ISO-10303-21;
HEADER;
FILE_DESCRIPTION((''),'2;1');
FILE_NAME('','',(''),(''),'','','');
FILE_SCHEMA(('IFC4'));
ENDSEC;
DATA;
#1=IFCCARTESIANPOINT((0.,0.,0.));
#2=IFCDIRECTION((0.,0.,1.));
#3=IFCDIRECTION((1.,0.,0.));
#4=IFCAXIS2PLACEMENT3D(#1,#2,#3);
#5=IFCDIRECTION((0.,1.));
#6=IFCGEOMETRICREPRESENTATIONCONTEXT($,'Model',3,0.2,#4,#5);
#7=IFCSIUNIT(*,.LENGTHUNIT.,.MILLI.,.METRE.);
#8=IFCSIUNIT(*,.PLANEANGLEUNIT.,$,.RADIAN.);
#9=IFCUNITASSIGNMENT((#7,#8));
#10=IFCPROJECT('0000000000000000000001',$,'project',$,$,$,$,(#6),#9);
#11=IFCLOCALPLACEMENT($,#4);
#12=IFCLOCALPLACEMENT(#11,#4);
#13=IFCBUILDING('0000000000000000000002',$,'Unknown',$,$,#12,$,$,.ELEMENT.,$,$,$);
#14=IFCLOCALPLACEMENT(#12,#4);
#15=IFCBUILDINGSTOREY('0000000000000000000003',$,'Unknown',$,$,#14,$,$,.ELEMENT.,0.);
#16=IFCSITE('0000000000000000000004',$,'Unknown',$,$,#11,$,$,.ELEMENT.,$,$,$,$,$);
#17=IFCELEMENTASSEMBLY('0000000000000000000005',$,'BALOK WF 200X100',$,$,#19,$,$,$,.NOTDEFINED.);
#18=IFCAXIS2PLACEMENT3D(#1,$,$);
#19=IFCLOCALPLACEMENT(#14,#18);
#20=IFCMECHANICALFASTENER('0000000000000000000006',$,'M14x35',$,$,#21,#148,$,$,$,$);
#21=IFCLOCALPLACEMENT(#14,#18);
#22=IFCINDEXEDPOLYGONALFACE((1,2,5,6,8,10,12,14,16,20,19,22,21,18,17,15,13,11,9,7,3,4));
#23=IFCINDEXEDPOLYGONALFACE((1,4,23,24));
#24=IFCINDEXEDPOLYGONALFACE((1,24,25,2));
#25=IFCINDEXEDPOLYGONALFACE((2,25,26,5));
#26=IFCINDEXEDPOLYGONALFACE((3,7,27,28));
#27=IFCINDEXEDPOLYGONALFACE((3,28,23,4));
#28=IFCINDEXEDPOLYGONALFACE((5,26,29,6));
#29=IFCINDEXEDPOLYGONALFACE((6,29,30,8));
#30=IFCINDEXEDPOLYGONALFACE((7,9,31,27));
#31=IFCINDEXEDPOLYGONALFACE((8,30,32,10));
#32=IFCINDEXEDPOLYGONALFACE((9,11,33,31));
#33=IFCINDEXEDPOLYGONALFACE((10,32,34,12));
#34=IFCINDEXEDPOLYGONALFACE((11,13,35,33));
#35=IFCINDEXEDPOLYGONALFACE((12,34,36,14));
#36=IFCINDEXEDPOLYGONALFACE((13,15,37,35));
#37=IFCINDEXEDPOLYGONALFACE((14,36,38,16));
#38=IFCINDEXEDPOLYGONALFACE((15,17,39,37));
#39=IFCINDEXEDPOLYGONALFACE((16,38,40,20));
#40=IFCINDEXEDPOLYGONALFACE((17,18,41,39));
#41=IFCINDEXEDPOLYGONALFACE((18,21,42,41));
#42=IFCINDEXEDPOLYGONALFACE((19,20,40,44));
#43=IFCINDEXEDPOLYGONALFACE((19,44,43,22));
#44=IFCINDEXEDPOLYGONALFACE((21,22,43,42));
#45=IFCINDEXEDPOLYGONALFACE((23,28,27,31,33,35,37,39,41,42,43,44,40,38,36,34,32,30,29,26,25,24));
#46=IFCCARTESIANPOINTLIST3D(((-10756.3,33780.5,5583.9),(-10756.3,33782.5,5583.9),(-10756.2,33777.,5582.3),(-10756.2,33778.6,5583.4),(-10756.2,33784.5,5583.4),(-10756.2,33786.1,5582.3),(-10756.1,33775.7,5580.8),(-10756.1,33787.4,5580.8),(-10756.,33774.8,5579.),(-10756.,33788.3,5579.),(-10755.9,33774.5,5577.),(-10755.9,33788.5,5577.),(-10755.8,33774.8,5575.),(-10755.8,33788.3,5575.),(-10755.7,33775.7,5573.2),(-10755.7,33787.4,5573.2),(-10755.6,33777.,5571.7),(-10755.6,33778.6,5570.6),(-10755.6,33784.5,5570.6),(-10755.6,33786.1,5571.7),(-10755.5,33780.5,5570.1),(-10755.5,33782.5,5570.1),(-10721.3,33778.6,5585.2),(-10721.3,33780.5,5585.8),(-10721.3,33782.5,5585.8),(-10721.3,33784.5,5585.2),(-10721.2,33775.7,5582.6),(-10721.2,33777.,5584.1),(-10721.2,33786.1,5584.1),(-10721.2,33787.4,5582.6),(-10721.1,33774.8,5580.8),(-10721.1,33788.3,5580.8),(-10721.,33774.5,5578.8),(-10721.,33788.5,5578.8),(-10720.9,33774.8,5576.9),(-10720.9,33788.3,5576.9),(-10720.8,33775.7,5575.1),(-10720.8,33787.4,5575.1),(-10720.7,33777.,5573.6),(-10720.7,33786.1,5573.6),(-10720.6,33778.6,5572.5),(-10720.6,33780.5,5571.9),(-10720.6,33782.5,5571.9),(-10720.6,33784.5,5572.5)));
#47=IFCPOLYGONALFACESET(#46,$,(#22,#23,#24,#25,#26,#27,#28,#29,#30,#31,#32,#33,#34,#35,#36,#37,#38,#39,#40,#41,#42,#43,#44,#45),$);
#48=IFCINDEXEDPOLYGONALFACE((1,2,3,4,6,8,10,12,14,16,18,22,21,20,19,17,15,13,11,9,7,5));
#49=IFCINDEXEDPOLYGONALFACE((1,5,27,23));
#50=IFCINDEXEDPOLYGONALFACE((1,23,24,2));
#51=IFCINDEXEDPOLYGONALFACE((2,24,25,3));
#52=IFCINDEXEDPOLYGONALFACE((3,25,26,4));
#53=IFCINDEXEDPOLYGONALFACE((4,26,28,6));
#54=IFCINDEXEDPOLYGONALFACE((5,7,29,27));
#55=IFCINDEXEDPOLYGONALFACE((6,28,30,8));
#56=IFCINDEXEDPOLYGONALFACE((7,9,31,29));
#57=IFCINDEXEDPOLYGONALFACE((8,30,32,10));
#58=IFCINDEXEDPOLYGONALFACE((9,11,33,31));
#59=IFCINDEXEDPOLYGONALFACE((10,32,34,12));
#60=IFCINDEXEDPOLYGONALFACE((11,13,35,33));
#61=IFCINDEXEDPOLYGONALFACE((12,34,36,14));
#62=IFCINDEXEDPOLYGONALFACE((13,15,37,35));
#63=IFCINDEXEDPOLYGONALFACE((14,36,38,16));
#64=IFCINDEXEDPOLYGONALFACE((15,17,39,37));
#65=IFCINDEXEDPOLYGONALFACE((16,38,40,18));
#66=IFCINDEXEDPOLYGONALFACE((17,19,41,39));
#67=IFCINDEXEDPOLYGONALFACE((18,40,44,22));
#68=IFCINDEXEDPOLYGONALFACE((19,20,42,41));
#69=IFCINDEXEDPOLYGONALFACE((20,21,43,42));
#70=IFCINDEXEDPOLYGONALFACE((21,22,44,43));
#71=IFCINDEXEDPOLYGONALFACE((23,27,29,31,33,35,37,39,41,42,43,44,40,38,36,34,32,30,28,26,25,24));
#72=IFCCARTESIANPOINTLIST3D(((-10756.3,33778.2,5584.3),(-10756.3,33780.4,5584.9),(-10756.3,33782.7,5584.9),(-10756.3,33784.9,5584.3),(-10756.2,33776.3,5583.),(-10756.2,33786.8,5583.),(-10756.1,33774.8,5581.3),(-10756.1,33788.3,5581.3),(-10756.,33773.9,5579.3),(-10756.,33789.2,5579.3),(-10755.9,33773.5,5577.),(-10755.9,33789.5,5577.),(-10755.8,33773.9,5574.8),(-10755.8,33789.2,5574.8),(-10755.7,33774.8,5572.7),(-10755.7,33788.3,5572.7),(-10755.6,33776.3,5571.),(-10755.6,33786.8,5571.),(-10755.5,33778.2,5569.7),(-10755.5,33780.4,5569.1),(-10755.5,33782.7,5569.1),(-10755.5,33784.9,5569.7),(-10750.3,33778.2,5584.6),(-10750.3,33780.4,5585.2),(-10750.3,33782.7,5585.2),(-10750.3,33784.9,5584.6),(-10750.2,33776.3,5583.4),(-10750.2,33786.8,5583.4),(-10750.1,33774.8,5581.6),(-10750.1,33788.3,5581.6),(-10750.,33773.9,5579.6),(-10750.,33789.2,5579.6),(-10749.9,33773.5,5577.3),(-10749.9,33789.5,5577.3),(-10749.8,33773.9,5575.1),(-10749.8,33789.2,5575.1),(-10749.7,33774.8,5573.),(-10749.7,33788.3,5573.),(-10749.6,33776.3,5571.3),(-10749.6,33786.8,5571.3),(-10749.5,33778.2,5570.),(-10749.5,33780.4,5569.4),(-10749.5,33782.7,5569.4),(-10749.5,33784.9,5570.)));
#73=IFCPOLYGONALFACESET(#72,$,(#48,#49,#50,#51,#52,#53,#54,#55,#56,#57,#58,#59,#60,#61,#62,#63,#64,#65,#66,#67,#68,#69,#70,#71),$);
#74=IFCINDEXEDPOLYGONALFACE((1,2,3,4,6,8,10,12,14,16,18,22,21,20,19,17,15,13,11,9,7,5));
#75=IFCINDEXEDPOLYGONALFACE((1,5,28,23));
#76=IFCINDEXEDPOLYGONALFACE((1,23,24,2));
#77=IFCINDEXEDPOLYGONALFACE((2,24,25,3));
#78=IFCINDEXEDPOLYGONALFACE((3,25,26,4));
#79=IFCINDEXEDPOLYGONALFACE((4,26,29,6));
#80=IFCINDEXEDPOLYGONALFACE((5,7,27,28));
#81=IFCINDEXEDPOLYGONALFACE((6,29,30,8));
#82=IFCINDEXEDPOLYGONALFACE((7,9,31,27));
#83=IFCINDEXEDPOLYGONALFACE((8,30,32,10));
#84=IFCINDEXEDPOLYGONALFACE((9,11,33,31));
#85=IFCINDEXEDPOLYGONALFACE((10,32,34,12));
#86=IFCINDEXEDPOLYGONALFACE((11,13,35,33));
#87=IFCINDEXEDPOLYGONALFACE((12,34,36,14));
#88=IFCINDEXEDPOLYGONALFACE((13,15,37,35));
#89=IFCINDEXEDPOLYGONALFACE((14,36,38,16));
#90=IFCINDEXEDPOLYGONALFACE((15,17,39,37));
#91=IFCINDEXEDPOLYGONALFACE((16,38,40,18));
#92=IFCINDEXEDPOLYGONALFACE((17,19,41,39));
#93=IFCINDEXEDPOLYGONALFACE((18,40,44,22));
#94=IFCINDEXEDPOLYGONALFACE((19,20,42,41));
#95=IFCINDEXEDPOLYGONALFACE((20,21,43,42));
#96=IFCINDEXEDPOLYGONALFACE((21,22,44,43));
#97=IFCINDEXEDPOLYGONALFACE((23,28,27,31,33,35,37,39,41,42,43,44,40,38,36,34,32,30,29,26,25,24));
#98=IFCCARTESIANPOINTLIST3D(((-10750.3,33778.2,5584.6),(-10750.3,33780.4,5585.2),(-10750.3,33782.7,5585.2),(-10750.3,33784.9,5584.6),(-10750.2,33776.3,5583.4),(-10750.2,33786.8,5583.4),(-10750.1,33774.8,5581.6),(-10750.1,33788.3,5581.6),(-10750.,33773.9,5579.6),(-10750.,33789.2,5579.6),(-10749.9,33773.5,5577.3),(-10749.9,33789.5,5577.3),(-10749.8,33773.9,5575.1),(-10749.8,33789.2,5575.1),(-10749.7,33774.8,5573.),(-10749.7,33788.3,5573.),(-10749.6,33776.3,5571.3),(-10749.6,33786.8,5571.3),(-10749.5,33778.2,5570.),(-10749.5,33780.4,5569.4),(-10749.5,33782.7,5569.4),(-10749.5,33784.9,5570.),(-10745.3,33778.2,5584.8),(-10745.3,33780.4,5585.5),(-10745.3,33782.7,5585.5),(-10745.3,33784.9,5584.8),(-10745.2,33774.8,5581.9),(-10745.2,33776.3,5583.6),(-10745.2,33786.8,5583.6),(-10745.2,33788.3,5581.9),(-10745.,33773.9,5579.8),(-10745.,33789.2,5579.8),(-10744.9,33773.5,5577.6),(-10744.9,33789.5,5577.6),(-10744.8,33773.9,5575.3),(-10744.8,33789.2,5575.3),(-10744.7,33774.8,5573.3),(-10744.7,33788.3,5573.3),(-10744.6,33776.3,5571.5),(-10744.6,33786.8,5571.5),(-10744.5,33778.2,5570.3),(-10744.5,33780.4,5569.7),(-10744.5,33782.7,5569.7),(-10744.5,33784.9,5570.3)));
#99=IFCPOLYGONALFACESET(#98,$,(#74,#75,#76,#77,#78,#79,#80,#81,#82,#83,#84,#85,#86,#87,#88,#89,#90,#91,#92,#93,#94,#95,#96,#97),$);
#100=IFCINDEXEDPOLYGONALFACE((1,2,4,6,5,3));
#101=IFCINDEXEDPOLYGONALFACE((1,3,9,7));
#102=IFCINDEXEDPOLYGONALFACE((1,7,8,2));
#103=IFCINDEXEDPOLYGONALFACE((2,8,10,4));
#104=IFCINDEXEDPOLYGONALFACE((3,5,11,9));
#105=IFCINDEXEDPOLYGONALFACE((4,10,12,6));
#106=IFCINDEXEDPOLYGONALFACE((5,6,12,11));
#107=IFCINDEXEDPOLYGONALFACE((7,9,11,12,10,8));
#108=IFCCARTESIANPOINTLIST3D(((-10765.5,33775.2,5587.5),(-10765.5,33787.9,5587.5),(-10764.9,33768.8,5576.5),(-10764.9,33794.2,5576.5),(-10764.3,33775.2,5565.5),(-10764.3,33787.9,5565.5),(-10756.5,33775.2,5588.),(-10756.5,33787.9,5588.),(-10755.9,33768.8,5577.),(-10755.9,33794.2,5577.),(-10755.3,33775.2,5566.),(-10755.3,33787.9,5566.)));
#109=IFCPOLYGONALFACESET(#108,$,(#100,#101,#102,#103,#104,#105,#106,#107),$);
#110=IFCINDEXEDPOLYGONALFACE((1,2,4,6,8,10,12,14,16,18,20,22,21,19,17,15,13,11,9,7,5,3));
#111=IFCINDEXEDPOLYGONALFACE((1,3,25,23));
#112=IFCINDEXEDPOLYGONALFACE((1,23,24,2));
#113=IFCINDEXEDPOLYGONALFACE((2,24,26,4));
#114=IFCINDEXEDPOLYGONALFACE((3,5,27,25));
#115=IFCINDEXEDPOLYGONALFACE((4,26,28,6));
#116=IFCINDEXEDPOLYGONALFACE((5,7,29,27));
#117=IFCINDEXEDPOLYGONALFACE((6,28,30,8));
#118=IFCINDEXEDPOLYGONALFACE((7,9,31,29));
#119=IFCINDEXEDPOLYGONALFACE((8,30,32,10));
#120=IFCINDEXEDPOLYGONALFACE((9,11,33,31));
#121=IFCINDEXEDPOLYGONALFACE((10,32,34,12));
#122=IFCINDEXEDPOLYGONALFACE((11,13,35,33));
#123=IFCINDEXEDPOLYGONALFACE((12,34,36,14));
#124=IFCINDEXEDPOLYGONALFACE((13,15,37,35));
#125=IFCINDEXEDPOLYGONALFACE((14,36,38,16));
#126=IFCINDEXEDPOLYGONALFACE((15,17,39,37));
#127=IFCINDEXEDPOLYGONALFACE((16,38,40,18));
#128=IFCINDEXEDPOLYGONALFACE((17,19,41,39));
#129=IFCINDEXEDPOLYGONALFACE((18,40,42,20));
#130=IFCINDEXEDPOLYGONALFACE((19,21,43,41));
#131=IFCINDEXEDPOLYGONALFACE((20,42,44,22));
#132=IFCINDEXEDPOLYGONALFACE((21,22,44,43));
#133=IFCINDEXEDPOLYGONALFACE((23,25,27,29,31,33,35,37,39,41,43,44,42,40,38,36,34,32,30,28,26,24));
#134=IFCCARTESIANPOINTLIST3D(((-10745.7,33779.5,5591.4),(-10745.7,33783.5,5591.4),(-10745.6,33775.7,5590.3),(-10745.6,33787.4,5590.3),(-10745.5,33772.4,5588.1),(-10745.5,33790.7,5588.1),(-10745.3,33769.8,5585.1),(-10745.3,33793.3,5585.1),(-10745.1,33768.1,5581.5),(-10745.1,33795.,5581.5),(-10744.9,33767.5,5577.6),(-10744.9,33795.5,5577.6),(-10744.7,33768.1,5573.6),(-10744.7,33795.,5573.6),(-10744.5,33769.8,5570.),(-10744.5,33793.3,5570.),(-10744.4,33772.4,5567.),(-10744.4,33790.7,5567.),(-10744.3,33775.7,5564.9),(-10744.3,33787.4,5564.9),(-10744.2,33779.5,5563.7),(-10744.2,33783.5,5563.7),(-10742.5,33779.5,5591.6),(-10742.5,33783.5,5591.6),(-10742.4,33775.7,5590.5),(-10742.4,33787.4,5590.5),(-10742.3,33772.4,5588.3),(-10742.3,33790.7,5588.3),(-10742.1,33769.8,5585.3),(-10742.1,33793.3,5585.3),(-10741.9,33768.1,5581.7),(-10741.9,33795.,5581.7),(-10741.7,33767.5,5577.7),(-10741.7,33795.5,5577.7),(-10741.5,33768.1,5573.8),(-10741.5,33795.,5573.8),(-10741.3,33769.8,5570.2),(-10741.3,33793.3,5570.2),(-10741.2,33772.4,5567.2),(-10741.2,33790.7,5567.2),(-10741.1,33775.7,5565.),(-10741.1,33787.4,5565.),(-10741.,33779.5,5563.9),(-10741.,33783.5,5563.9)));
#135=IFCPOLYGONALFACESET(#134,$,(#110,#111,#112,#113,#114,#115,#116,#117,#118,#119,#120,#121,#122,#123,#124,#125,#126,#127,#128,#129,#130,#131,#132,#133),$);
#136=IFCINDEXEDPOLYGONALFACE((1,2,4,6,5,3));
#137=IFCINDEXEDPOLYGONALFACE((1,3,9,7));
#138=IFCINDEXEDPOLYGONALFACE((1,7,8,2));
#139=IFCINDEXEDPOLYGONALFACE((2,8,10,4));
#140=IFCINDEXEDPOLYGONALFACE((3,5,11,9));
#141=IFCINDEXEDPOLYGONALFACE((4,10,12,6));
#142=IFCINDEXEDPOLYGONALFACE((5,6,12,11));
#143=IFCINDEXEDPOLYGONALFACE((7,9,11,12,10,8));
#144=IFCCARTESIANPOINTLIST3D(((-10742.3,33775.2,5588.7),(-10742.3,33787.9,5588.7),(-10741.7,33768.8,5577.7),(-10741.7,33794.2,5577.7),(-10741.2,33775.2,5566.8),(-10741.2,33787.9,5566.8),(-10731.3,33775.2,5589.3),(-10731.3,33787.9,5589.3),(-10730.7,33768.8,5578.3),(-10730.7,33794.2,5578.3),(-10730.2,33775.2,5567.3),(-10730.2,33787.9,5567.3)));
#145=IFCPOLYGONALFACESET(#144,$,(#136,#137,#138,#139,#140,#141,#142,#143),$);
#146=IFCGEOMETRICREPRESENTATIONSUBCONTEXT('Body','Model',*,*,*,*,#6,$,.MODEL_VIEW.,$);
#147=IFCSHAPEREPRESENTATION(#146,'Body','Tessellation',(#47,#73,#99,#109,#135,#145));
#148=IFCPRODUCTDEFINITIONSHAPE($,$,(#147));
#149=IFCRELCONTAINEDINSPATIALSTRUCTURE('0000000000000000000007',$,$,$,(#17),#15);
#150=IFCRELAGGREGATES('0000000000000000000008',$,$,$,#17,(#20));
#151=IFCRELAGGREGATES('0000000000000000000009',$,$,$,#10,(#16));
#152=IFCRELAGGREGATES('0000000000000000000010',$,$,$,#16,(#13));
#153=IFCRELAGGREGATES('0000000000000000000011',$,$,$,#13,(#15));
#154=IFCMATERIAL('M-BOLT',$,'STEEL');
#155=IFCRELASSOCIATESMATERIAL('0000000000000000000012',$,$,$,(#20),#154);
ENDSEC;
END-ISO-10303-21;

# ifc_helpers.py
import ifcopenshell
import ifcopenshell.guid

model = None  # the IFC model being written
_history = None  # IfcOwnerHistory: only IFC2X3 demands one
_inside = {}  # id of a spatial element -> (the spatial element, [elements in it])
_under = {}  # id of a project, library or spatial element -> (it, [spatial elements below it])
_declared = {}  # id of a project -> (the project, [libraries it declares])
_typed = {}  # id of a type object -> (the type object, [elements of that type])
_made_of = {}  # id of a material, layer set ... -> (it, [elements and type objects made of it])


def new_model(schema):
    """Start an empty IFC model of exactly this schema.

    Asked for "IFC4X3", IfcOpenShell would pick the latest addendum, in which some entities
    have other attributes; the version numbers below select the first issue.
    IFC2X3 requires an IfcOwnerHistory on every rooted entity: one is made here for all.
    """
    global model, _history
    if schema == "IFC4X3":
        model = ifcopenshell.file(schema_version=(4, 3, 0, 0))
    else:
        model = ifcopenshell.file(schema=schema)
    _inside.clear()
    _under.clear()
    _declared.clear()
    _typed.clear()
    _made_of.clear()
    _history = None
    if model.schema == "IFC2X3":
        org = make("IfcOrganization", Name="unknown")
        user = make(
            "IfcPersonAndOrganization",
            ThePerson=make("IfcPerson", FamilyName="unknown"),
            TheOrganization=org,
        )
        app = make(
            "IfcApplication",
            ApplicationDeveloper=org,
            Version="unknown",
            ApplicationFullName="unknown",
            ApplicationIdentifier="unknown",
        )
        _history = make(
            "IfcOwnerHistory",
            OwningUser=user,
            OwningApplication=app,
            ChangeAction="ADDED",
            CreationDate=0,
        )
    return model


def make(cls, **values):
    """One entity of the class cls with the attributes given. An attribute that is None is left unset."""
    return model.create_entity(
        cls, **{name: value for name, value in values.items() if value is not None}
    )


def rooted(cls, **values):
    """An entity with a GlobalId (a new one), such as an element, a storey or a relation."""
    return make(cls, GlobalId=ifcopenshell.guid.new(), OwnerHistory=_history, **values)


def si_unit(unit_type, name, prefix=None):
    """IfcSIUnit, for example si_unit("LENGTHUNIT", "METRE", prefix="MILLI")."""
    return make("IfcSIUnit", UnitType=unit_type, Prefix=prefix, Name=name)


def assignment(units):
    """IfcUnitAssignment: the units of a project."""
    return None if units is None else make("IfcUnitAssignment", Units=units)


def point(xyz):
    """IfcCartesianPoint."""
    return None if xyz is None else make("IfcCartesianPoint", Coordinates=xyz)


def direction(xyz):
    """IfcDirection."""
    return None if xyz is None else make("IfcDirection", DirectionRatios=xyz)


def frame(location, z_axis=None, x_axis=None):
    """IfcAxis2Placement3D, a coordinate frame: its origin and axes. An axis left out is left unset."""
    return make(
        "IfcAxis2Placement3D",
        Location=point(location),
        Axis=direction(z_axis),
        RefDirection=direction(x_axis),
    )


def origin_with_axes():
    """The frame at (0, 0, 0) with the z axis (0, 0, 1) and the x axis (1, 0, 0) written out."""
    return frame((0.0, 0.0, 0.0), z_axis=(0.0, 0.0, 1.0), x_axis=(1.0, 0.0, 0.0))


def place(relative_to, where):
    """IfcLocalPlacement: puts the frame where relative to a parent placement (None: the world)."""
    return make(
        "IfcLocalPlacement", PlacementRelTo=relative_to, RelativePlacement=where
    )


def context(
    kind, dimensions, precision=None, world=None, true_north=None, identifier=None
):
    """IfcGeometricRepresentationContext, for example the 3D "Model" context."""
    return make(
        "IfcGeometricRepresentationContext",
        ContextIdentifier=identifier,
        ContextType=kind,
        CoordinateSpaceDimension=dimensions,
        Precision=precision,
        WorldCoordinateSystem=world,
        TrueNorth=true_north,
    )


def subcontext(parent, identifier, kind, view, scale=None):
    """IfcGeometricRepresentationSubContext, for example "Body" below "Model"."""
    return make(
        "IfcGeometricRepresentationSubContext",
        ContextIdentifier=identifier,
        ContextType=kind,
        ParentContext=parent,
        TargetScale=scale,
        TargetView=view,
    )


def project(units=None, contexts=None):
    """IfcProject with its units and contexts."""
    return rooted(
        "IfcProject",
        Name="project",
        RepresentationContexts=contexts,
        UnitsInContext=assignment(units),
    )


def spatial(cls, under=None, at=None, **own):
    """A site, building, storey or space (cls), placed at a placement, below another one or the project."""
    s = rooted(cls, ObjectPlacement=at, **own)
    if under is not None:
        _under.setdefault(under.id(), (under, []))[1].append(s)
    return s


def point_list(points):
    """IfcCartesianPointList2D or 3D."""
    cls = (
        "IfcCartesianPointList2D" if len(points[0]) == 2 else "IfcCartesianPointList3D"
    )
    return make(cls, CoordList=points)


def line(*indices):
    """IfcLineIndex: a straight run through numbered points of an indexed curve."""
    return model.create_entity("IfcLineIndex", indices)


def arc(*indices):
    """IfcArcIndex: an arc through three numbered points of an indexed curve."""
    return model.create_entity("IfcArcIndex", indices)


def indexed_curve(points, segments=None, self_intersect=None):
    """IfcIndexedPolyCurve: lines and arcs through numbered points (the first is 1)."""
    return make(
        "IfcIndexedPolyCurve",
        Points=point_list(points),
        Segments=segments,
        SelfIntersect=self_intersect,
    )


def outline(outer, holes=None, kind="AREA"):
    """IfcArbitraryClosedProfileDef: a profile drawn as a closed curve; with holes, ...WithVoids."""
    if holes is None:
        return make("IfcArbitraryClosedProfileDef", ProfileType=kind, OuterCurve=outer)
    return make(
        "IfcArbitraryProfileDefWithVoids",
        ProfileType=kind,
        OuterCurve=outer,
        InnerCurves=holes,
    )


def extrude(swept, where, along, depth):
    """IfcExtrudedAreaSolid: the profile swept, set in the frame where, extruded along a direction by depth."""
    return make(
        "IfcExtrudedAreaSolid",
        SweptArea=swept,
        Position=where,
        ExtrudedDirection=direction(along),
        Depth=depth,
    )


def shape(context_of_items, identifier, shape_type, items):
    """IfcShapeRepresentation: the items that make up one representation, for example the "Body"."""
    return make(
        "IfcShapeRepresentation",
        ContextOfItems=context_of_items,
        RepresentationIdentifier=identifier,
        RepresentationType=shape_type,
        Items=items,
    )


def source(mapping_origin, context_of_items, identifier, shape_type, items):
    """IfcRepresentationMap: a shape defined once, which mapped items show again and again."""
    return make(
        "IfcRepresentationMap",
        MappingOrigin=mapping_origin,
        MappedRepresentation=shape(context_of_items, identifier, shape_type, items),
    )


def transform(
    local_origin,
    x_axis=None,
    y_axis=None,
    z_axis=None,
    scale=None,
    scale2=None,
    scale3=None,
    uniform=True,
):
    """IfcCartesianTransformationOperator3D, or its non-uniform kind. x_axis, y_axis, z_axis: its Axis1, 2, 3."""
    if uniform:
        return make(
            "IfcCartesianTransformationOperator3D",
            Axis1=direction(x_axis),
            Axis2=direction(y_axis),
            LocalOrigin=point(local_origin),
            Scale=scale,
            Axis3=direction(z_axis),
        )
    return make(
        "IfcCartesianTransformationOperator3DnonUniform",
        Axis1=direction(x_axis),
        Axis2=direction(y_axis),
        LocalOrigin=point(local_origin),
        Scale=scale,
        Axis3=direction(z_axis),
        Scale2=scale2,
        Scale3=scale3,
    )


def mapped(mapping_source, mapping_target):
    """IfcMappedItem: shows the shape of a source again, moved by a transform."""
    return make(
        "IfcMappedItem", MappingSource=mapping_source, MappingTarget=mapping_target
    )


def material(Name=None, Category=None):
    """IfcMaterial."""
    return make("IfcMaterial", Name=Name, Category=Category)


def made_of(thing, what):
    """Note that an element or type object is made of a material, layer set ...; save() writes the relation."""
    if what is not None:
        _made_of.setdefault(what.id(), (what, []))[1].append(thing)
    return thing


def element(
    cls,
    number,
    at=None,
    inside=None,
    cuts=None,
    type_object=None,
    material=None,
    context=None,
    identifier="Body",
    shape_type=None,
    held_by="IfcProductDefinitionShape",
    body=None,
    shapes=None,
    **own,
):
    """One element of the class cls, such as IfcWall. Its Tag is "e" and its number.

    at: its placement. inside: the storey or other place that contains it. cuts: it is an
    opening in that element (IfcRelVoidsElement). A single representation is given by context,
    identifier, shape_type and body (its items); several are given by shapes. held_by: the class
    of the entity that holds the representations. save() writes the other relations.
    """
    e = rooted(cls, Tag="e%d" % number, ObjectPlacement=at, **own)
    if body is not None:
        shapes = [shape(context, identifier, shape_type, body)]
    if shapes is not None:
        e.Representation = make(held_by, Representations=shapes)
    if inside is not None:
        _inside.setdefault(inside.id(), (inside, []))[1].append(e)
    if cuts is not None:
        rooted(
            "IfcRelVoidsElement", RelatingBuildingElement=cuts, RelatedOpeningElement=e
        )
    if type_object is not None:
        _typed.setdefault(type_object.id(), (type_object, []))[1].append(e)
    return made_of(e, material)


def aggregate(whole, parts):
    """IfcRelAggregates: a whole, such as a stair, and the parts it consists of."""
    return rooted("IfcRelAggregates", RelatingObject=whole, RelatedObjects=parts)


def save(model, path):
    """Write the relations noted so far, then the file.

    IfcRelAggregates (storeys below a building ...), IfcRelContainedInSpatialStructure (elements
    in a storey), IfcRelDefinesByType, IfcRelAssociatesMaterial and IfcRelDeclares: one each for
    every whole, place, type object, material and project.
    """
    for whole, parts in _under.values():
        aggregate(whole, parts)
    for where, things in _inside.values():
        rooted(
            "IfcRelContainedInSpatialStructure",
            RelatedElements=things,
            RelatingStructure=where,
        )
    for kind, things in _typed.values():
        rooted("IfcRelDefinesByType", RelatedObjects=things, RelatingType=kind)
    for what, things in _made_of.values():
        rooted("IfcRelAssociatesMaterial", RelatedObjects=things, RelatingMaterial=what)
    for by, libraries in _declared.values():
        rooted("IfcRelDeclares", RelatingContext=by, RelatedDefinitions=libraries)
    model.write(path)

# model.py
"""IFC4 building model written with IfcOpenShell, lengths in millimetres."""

from ifc_helpers import new_model, si_unit, direction, frame, origin_with_axes, place, context, subcontext, project, spatial, line, arc, indexed_curve, outline, extrude, source, transform, mapped, material, element, aggregate, save


model = new_model("IFC4")

# Units and contexts
model_context = context("Model", 3, precision=0.2, world=origin_with_axes(), true_north=direction((0.0, 1.0)))
body_context = subcontext(model_context, "Body", "Model", "MODEL_VIEW")
ifc_project = project(units=[si_unit("LENGTHUNIT", "METRE", prefix="MILLI"), si_unit("PLANEANGLEUNIT", "RADIAN")], contexts=[model_context])

# Site, building, storey
site_placement = place(None, origin_with_axes())
site = spatial("IfcSite", under=ifc_project, at=site_placement, Name="Unknown", CompositionType="ELEMENT")
building_placement = place(site_placement, origin_with_axes())
building = spatial("IfcBuilding", under=site, at=building_placement, Name="Unknown", CompositionType="ELEMENT")
storey_placement = place(building_placement, origin_with_axes())
storey = spatial("IfcBuildingStorey", under=building, at=storey_placement, Name="Unknown", CompositionType="ELEMENT", Elevation=0.0)

# Shared definitions
ifc_material_1 = material(Name="M-BOLT", Category="STEEL")

# Element assembly, mechanical fastener
assembly_1_placement = place(storey_placement, frame((-7044.1, 33866.5, 5721.5), z_axis=(0.0, 1.0, 0.0), x_axis=(-0.99863, 0.0, -0.052336)))
assembly_1 = element("IfcElementAssembly", 1, at=assembly_1_placement, inside=storey, Name="BALOK WF 200X100", PredefinedType="NOTDEFINED")
shared_shape_1 = source(origin_with_axes(), body_context, "Body", "SweptSolid", [
    extrude(outline(indexed_curve([(7.0, 0.0), (0.0, 7.0), (-7.0, 0.0), (0.0, -7.0)], segments=[arc(1, 2, 3), arc(3, 4, 1)])), frame((0.0, 0.0, 0.0), z_axis=(0.0, 0.0, -1.0), x_axis=(0.0, 1.0, 0.0)), (0.0, 0.0, 1.0), 35.0),
    extrude(outline(indexed_curve([(8.0, 0.0), (0.0, 8.0), (-8.0, 0.0), (0.0, -8.0)], segments=[arc(1, 2, 3), arc(3, 4, 1)])), frame((0.0, 0.0, 0.0), z_axis=(0.0, 0.0, -1.0), x_axis=(0.0, 1.0, 0.0)), (0.0, 0.0, 1.0), 6.0),
    extrude(outline(indexed_curve([(8.0, 0.0), (0.0, 8.0), (-8.0, 0.0), (0.0, -8.0)], segments=[arc(1, 2, 3), arc(3, 4, 1)])), frame((0.0, 0.0, -6.0), z_axis=(0.0, 0.0, -1.0), x_axis=(0.0, 1.0, 0.0)), (0.0, 0.0, 1.0), 5.0),
    extrude(outline(indexed_curve([(12.7, 0.0), (6.4, 11.0), (-6.4, 11.0), (-12.7, 0.0), (-6.4, -11.0), (6.4, -11.0)], segments=[line(1, 2, 3, 4, 5, 6, 1)])), frame((0.0, 0.0, 9.0), z_axis=(0.0, 0.0, -1.0), x_axis=(0.0, 1.0, 0.0)), (0.0, 0.0, 1.0), 9.0),
    extrude(outline(indexed_curve([(14.0, 0.0), (0.0, 14.0), (-14.0, 0.0), (0.0, -14.0)], segments=[arc(1, 2, 3), arc(3, 4, 1)])), frame((0.0, 0.0, -11.0), z_axis=(0.0, 0.0, -1.0), x_axis=(0.0, 1.0, 0.0)), (0.0, 0.0, 1.0), 3.2),
    extrude(outline(indexed_curve([(12.7, 0.0), (6.4, 11.0), (-6.4, 11.0), (-12.7, 0.0), (-6.4, -11.0), (6.4, -11.0)], segments=[line(1, 2, 3, 4, 5, 6, 1)])), frame((0.0, 0.0, -14.2), z_axis=(0.0, 0.0, -1.0), x_axis=(0.0, 1.0, 0.0)), (0.0, 0.0, 1.0), 11.0),
])
mechanical_fastener_1_placement = place(assembly_1_placement, frame((3714.2, 50.0, -85.0), z_axis=(1.0, 0.0, -0.000006), x_axis=(0.0, -1.0, 0.0)))
mechanical_fastener_1 = element("IfcMechanicalFastener", 2, at=mechanical_fastener_1_placement, material=ifc_material_1, Name="M14x35", context=body_context, shape_type="MappedRepresentation", body=[
    mapped(shared_shape_1, transform((0.0, 0.0, 0.0))),
])

aggregate(assembly_1, [mechanical_fastener_1])

save(model, "model.ifc")
